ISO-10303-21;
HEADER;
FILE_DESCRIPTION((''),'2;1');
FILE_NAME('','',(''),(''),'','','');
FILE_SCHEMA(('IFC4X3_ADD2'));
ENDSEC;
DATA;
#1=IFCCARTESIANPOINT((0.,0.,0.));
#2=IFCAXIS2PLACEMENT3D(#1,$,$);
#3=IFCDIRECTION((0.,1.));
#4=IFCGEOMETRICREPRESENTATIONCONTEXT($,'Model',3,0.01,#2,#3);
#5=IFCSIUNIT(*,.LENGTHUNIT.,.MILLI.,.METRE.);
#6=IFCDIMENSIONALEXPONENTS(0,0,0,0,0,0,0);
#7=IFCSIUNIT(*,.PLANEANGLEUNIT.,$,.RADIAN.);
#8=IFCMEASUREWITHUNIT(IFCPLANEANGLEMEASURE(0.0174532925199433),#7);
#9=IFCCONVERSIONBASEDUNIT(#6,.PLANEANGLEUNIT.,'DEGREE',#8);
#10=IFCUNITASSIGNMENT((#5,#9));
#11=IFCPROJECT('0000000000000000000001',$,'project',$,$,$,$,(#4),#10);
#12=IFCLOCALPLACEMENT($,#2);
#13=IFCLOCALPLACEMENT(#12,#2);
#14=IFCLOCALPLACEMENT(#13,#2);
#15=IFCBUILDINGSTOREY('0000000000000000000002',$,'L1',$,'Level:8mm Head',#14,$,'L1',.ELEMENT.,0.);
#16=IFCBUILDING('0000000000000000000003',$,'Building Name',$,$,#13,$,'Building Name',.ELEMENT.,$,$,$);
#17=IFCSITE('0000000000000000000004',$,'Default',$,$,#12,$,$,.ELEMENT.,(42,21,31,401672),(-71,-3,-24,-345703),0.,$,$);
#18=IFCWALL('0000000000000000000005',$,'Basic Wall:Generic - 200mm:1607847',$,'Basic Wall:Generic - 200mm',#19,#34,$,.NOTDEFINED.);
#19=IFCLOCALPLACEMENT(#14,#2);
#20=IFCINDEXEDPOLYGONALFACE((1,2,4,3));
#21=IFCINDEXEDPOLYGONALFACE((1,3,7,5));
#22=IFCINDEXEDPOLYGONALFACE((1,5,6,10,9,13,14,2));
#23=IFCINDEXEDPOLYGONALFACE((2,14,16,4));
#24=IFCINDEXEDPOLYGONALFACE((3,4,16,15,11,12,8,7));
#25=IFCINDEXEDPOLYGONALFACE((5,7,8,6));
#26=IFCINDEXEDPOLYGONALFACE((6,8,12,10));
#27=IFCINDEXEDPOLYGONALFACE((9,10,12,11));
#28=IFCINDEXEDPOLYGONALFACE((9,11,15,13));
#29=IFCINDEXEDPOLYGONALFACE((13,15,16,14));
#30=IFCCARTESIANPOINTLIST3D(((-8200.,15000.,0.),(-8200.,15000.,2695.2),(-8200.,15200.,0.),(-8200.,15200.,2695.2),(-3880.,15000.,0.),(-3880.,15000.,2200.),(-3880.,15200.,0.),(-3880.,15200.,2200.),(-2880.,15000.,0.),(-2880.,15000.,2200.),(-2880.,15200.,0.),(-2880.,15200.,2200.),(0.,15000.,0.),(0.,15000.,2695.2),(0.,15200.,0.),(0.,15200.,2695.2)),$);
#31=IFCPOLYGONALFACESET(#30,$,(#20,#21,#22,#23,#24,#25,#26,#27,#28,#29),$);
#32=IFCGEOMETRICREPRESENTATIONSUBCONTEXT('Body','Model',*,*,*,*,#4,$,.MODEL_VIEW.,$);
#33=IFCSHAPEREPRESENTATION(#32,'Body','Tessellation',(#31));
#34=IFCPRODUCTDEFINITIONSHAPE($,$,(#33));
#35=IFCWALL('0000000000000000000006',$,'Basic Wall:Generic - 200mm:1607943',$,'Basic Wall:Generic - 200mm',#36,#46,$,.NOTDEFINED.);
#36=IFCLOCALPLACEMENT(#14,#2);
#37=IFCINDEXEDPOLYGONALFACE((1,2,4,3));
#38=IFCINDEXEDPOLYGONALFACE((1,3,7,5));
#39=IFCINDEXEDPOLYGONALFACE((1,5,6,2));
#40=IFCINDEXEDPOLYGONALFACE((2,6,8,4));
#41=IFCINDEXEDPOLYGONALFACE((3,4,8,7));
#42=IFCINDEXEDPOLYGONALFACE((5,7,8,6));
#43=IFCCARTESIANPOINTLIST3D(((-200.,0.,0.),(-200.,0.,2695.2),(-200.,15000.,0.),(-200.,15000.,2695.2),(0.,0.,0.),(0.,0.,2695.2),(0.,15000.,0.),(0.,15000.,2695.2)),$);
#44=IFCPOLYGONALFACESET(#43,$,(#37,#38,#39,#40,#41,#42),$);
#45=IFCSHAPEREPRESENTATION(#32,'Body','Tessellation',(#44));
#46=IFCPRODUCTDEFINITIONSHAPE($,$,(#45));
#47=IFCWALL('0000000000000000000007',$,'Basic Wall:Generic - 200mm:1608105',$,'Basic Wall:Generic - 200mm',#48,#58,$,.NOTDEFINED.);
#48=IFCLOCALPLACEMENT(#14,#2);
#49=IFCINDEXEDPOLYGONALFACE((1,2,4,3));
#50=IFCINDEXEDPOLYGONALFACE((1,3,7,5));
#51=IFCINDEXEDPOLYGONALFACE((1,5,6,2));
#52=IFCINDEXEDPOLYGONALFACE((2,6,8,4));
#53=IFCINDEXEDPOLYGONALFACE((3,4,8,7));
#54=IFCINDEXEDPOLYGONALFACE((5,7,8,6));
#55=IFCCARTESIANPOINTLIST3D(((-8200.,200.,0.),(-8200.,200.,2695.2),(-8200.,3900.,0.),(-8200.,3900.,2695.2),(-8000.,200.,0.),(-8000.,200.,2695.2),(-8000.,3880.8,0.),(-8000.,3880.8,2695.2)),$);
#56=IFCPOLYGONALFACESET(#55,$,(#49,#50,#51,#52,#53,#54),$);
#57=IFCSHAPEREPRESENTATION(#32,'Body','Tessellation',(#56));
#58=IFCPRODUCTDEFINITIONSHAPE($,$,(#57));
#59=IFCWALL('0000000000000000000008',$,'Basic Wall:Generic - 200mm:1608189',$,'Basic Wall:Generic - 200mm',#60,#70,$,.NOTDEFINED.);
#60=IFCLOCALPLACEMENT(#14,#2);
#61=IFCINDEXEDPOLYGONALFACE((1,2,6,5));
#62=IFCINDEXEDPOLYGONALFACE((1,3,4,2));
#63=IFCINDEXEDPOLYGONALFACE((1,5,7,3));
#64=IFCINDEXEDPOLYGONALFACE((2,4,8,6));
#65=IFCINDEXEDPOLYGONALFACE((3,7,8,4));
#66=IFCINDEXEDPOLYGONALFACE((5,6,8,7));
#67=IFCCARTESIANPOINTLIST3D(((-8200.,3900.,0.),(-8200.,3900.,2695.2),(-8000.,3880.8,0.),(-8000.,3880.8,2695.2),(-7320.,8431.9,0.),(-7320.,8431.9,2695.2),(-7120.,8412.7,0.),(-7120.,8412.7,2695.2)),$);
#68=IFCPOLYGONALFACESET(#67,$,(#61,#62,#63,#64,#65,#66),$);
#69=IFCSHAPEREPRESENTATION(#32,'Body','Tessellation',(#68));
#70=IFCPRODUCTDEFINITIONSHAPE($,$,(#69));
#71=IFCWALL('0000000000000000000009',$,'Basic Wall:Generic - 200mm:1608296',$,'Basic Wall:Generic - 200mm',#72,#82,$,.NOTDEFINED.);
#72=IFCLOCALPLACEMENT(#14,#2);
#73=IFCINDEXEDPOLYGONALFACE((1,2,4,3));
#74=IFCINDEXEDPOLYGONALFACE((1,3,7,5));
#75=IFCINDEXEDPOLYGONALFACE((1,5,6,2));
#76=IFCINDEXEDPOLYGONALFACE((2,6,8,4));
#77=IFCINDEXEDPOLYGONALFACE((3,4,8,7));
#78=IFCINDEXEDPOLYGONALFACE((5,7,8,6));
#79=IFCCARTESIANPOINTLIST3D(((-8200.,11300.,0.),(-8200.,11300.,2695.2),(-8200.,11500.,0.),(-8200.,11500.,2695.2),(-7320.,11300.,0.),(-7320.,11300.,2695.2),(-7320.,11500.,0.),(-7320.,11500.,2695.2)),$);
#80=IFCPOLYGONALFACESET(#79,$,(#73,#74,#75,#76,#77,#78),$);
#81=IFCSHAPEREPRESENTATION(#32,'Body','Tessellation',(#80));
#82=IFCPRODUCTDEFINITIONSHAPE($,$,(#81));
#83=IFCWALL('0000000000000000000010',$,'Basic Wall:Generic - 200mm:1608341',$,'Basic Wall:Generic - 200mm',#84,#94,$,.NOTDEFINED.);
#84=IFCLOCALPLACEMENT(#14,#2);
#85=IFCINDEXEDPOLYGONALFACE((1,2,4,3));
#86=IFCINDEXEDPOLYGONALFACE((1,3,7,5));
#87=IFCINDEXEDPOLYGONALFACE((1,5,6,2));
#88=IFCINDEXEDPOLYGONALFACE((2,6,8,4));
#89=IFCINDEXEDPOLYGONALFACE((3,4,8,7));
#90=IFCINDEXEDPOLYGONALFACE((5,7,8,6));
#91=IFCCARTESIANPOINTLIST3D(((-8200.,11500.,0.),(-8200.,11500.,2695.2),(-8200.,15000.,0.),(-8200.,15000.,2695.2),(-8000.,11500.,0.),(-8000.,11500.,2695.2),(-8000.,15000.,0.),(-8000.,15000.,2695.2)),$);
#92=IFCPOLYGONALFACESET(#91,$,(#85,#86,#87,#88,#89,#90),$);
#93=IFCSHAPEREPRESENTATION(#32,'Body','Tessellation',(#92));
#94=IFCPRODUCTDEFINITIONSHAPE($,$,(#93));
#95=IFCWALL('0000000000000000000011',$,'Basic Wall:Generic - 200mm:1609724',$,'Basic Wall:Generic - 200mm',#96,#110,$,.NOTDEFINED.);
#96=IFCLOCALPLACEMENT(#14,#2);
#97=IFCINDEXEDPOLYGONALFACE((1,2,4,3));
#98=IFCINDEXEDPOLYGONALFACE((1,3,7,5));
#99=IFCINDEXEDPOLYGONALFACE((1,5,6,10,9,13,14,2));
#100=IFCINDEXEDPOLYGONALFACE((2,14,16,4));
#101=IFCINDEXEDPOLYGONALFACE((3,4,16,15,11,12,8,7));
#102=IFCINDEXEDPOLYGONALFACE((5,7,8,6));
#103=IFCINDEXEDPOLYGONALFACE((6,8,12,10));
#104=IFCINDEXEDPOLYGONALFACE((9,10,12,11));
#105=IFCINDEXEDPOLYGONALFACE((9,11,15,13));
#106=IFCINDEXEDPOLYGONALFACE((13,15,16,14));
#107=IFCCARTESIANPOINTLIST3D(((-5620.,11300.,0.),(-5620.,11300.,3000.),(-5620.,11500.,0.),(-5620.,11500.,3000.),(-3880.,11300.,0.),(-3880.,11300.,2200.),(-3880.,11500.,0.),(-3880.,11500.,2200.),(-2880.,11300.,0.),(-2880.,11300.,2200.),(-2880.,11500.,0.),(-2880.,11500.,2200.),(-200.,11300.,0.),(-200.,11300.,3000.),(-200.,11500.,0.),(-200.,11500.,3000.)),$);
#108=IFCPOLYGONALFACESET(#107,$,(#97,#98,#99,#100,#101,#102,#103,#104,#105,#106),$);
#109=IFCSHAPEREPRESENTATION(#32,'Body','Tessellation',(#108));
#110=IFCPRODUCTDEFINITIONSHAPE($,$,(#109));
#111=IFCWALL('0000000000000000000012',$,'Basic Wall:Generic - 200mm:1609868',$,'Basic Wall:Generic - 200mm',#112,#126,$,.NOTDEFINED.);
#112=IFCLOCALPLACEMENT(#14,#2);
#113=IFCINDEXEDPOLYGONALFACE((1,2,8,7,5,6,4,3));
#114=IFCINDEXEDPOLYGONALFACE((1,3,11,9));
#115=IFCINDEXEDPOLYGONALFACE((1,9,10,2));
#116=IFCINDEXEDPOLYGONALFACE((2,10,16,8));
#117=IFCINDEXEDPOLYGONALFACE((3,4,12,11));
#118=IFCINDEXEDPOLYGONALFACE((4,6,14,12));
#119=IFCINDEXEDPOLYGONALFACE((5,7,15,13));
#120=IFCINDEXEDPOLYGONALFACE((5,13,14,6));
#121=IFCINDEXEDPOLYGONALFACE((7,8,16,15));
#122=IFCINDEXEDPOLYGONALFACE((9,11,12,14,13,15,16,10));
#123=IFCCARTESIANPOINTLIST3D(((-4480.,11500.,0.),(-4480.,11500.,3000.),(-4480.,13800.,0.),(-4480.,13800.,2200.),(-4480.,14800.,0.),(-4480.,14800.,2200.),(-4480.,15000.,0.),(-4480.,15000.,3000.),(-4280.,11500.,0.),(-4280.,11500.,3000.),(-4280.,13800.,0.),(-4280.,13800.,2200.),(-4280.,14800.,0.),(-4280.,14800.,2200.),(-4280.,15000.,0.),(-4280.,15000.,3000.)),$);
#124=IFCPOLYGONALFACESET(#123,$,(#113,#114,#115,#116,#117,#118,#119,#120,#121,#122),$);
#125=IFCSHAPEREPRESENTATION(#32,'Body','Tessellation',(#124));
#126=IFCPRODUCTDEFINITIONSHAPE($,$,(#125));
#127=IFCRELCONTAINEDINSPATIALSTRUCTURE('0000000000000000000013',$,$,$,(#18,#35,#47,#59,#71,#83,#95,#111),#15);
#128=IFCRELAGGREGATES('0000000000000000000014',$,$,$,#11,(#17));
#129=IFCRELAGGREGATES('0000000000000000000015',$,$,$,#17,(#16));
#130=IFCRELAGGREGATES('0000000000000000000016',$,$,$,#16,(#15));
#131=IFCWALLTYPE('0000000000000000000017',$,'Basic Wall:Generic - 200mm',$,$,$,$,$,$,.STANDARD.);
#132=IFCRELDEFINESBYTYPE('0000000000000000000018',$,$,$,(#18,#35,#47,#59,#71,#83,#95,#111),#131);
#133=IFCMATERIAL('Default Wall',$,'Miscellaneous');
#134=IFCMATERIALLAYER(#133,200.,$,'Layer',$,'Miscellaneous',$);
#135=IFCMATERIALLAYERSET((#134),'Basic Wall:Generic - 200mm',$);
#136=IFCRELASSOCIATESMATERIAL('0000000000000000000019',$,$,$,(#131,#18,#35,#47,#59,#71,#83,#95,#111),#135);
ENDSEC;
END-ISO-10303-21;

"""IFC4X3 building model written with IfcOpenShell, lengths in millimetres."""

from ifc_helpers import new_model, entity, si_unit, converted_unit, direction, frame, frame_2d, origin, place, context, subcontext, project, spatial, polyline, rectangle, outline, extrude, clip, bounded_halfspace, material, layer, layer_set, type_object, element, save


model = new_model("IFC4X3")

# Units and contexts
model_context = context("Model", 3, precision=0.01, world=origin(), true_north=direction((0.0, 1.0)))
body_context = subcontext(model_context, "Body", "Model", "MODEL_VIEW")
ifc_project = project(units=[si_unit("LENGTHUNIT", "METRE", prefix="MILLI"), converted_unit("PLANEANGLEUNIT", "DEGREE", entity("IfcPlaneAngleMeasure", 0.0174532925199433), si_unit("PLANEANGLEUNIT", "RADIAN"), dimensions=[0, 0, 0, 0, 0, 0, 0])], contexts=[model_context])

# Site, building, storey
site_placement = place(None, origin())
site = spatial("IfcSite", under=ifc_project, at=site_placement, Name="Default", CompositionType="ELEMENT", RefLatitude=(42, 21, 31, 401672), RefLongitude=(-71, -3, -24, -345703), RefElevation=0.0)
building_placement = place(site_placement, origin())
building = spatial("IfcBuilding", under=site, at=building_placement, Name="Building Name", LongName="Building Name", CompositionType="ELEMENT")
storey_placement = place(building_placement, origin())
storey = spatial("IfcBuildingStorey", under=building, at=storey_placement, Name="L1", ObjectType="Level:8mm Head", LongName="L1", CompositionType="ELEMENT", Elevation=0.0)

# Wall, opening
ifc_material = material(Name="Default Wall", Category="Miscellaneous")
ifc_layer = layer(ifc_material, 200.0, Name="Layer", Category="Miscellaneous")
ifc_layer_set = layer_set([ifc_layer], Name="Basic Wall:Generic - 200mm")
wall_type = type_object("IfcWallType", Name="Basic Wall:Generic - 200mm", PredefinedType="STANDARD", material=ifc_layer_set)
wall_1_placement = place(storey_placement, frame((-8200.0, 15100.0, 0.0)))
wall_1 = element("IfcWall", 1, at=wall_1_placement, inside=storey, type_object=wall_type, material=ifc_layer_set, Name="Basic Wall:Generic - 200mm:1607847", ObjectType="Basic Wall:Generic - 200mm", PredefinedType="NOTDEFINED", context=body_context, shape_type="Clipping", body=[
    clip(extrude(rectangle(XDim=8200.0, YDim=200.0, at=frame_2d((4100.0, 0.0), x_axis=(1.0, 0.0))), origin(), (0.0, 0.0, 1.0), 2695.2), bounded_halfspace(frame((0.0, -100.0, 2695.2), z_axis=(0.0, 0.0, -1.0), x_axis=(0.0, 1.0, 0.0)), True, frame((0.0, -100.0, 2695.2)), polyline([(0.0, 0.0), (200.0, 0.0), (8000.0, 0.0), (8200.0, 0.0), (8200.0, 200.0), (0.0, 200.0), (0.0, 0.0)]))),
])
opening_1_placement = place(wall_1_placement, frame((5320.0, 100.0, 0.0)))
element("IfcOpeningElement", 2, at=opening_1_placement, cuts=wall_1, PredefinedType="OPENING", context=body_context, shape_type="SweptSolid", body=[
    extrude(rectangle(XDim=2200.0, YDim=1000.0, at=frame_2d((1100.0, 500.0), x_axis=(1.0, 0.0))), frame((0.0, 0.0, 0.0), z_axis=(0.0, -1.0, 0.0), x_axis=(0.0, 0.0, 1.0)), (0.0, 0.0, 1.0), 200.0),
])

# Wall
wall_2_placement = place(storey_placement, frame((-100.0, 15000.0, 0.0), z_axis=(0.0, 0.0, 1.0), x_axis=(0.0, -1.0, 0.0)))
element("IfcWall", 3, at=wall_2_placement, inside=storey, type_object=wall_type, material=ifc_layer_set, Name="Basic Wall:Generic - 200mm:1607943", ObjectType="Basic Wall:Generic - 200mm", PredefinedType="NOTDEFINED", context=body_context, shape_type="Clipping", body=[
    clip(extrude(rectangle(XDim=15000.0, YDim=200.0, at=frame_2d((7500.0, 0.0), x_axis=(-1.0, 0.0))), origin(), (0.0, 0.0, 1.0), 2695.2), bounded_halfspace(frame((0.0, -100.0, 2695.2), z_axis=(0.0, 0.0, -1.0), x_axis=(-1.0, 0.0, 0.0)), True, frame((0.0, -100.0, 2695.2)), polyline([(0.0, 0.0), (14800.0, 0.0), (15000.0, 0.0), (15000.0, 200.0), (0.0, 200.0), (0.0, 0.0)]))),
])

# Walls
wall_3_placement = place(storey_placement, frame((-8100.0, 3900.0, 0.0), z_axis=(0.0, 0.0, 1.0), x_axis=(0.0, -1.0, 0.0)))
element("IfcWall", 4, at=wall_3_placement, inside=storey, type_object=wall_type, material=ifc_layer_set, Name="Basic Wall:Generic - 200mm:1608105", ObjectType="Basic Wall:Generic - 200mm", PredefinedType="NOTDEFINED", context=body_context, shape_type="Clipping", body=[
    clip(extrude(outline(polyline([(3700.0, -100.0), (3700.0, 100.0), (19.2, 100.0), (0.0, -100.0), (3700.0, -100.0)])), origin(), (0.0, 0.0, 1.0), 2695.2), bounded_halfspace(frame((0.0, -100.0, 2695.2), z_axis=(0.0, 0.0, -1.0), x_axis=(-1.0, 0.0, 0.0)), True, frame((0.0, -100.0, 2695.2)), polyline([(0.0, 0.0), (3700.0, 0.0), (3700.0, 200.0), (19.2, 200.0), (0.0, 0.0)]))),
])
wall_4_placement = place(storey_placement, frame((-8101.8, 3880.9, 0.0), z_axis=(0.0, 0.0, 1.0), x_axis=(0.190619, 0.981664, 0.0)))
element("IfcWall", 5, at=wall_4_placement, inside=storey, type_object=wall_type, material=ifc_layer_set, Name="Basic Wall:Generic - 200mm:1608189", ObjectType="Basic Wall:Generic - 200mm", PredefinedType="NOTDEFINED", context=body_context, shape_type="Clipping", body=[
    clip(extrude(outline(polyline([(4635.8, -100.0), (4616.5, 100.0), (0.0, 100.0), (19.2, -100.0), (4635.8, -100.0)])), origin(), (0.0, 0.0, 1.0), 2695.2), bounded_halfspace(frame((19.2, -100.0, 2695.2), z_axis=(0.0, 0.0, -1.0), x_axis=(0.981664, 0.190619, 0.0)), True, frame((19.2, -100.0, 2695.2)), polyline([(0.0, 0.0), (4616.5, 0.0), (4597.3, 200.0), (-19.2, 200.0), (0.0, 0.0)]))),
])
wall_5_placement = place(storey_placement, frame((-7320.0, 11400.0, 0.0), z_axis=(0.0, 0.0, 1.0), x_axis=(-1.0, 0.0, 0.0)))
element("IfcWall", 6, at=wall_5_placement, inside=storey, type_object=wall_type, material=ifc_layer_set, Name="Basic Wall:Generic - 200mm:1608296", ObjectType="Basic Wall:Generic - 200mm", PredefinedType="NOTDEFINED", context=body_context, shape_type="Clipping", body=[
    clip(extrude(rectangle(XDim=880.0, YDim=200.0, at=frame_2d((440.0, 0.0), x_axis=(-1.0, 0.0))), origin(), (0.0, 0.0, 1.0), 2695.2), bounded_halfspace(frame((0.0, -100.0, 2695.2), z_axis=(0.0, 0.0, -1.0), x_axis=(0.0, -1.0, 0.0)), True, frame((0.0, -100.0, 2695.2)), polyline([(0.0, 0.0), (680.0, 0.0), (880.0, 0.0), (880.0, 200.0), (0.0, 200.0), (0.0, 0.0)]))),
])
wall_6_placement = place(storey_placement, frame((-8100.0, 11500.0, 0.0), z_axis=(0.0, 0.0, 1.0), x_axis=(0.0, 1.0, 0.0)))
element("IfcWall", 7, at=wall_6_placement, inside=storey, type_object=wall_type, material=ifc_layer_set, Name="Basic Wall:Generic - 200mm:1608341", ObjectType="Basic Wall:Generic - 200mm", PredefinedType="NOTDEFINED", context=body_context, shape_type="Clipping", body=[
    clip(extrude(rectangle(XDim=3500.0, YDim=200.0, at=frame_2d((1750.0, 0.0), x_axis=(-1.0, 0.0))), origin(), (0.0, 0.0, 1.0), 2695.2), bounded_halfspace(frame((0.0, -100.0, 2695.2), z_axis=(0.0, 0.0, -1.0), x_axis=(1.0, 0.0, 0.0)), True, frame((0.0, -100.0, 2695.2)), polyline([(0.0, 0.0), (3500.0, 0.0), (3500.0, 200.0), (0.0, 200.0), (0.0, 0.0)]))),
])

# Walls, openings
wall_7_placement = place(storey_placement, frame((-5620.0, 11400.0, 0.0)))
wall_7 = element("IfcWall", 8, at=wall_7_placement, inside=storey, type_object=wall_type, material=ifc_layer_set, Name="Basic Wall:Generic - 200mm:1609724", ObjectType="Basic Wall:Generic - 200mm", PredefinedType="NOTDEFINED", context=body_context, shape_type="SweptSolid", body=[
    extrude(rectangle(XDim=5420.0, YDim=200.0, at=frame_2d((2710.0, 0.0), x_axis=(-1.0, 0.0))), origin(), (0.0, 0.0, 1.0), 3000.0),
])
opening_2_placement = place(wall_7_placement, frame((1740.0, -100.0, 0.0)))
element("IfcOpeningElement", 9, at=opening_2_placement, cuts=wall_7, PredefinedType="OPENING", context=body_context, shape_type="SweptSolid", body=[
    extrude(rectangle(XDim=2200.0, YDim=1000.0, at=frame_2d((1100.0, 500.0), x_axis=(1.0, 0.0))), frame((0.0, 0.0, 0.0), z_axis=(0.0, 1.0, 0.0), x_axis=(0.0, 0.0, 1.0)), (0.0, 0.0, 1.0), 200.0),
])
wall_8_placement = place(storey_placement, frame((-4380.0, 11500.0, 0.0), z_axis=(0.0, 0.0, 1.0), x_axis=(0.0, 1.0, 0.0)))
wall_8 = element("IfcWall", 10, at=wall_8_placement, inside=storey, type_object=wall_type, material=ifc_layer_set, Name="Basic Wall:Generic - 200mm:1609868", ObjectType="Basic Wall:Generic - 200mm", PredefinedType="NOTDEFINED", context=body_context, shape_type="SweptSolid", body=[
    extrude(rectangle(XDim=3500.0, YDim=200.0, at=frame_2d((1750.0, 0.0), x_axis=(-1.0, 0.0))), origin(), (0.0, 0.0, 1.0), 3000.0),
])
opening_3_placement = place(wall_8_placement, frame((2300.0, -100.0, 0.0)))
element("IfcOpeningElement", 11, at=opening_3_placement, cuts=wall_8, PredefinedType="OPENING", context=body_context, shape_type="SweptSolid", body=[
    extrude(rectangle(XDim=2200.0, YDim=1000.0, at=frame_2d((1100.0, 500.0), x_axis=(1.0, 0.0))), frame((0.0, 0.0, 0.0), z_axis=(0.0, 1.0, 0.0), x_axis=(0.0, 0.0, 1.0)), (0.0, 0.0, 1.0), 200.0),
])

save(model, "model.ifc")
